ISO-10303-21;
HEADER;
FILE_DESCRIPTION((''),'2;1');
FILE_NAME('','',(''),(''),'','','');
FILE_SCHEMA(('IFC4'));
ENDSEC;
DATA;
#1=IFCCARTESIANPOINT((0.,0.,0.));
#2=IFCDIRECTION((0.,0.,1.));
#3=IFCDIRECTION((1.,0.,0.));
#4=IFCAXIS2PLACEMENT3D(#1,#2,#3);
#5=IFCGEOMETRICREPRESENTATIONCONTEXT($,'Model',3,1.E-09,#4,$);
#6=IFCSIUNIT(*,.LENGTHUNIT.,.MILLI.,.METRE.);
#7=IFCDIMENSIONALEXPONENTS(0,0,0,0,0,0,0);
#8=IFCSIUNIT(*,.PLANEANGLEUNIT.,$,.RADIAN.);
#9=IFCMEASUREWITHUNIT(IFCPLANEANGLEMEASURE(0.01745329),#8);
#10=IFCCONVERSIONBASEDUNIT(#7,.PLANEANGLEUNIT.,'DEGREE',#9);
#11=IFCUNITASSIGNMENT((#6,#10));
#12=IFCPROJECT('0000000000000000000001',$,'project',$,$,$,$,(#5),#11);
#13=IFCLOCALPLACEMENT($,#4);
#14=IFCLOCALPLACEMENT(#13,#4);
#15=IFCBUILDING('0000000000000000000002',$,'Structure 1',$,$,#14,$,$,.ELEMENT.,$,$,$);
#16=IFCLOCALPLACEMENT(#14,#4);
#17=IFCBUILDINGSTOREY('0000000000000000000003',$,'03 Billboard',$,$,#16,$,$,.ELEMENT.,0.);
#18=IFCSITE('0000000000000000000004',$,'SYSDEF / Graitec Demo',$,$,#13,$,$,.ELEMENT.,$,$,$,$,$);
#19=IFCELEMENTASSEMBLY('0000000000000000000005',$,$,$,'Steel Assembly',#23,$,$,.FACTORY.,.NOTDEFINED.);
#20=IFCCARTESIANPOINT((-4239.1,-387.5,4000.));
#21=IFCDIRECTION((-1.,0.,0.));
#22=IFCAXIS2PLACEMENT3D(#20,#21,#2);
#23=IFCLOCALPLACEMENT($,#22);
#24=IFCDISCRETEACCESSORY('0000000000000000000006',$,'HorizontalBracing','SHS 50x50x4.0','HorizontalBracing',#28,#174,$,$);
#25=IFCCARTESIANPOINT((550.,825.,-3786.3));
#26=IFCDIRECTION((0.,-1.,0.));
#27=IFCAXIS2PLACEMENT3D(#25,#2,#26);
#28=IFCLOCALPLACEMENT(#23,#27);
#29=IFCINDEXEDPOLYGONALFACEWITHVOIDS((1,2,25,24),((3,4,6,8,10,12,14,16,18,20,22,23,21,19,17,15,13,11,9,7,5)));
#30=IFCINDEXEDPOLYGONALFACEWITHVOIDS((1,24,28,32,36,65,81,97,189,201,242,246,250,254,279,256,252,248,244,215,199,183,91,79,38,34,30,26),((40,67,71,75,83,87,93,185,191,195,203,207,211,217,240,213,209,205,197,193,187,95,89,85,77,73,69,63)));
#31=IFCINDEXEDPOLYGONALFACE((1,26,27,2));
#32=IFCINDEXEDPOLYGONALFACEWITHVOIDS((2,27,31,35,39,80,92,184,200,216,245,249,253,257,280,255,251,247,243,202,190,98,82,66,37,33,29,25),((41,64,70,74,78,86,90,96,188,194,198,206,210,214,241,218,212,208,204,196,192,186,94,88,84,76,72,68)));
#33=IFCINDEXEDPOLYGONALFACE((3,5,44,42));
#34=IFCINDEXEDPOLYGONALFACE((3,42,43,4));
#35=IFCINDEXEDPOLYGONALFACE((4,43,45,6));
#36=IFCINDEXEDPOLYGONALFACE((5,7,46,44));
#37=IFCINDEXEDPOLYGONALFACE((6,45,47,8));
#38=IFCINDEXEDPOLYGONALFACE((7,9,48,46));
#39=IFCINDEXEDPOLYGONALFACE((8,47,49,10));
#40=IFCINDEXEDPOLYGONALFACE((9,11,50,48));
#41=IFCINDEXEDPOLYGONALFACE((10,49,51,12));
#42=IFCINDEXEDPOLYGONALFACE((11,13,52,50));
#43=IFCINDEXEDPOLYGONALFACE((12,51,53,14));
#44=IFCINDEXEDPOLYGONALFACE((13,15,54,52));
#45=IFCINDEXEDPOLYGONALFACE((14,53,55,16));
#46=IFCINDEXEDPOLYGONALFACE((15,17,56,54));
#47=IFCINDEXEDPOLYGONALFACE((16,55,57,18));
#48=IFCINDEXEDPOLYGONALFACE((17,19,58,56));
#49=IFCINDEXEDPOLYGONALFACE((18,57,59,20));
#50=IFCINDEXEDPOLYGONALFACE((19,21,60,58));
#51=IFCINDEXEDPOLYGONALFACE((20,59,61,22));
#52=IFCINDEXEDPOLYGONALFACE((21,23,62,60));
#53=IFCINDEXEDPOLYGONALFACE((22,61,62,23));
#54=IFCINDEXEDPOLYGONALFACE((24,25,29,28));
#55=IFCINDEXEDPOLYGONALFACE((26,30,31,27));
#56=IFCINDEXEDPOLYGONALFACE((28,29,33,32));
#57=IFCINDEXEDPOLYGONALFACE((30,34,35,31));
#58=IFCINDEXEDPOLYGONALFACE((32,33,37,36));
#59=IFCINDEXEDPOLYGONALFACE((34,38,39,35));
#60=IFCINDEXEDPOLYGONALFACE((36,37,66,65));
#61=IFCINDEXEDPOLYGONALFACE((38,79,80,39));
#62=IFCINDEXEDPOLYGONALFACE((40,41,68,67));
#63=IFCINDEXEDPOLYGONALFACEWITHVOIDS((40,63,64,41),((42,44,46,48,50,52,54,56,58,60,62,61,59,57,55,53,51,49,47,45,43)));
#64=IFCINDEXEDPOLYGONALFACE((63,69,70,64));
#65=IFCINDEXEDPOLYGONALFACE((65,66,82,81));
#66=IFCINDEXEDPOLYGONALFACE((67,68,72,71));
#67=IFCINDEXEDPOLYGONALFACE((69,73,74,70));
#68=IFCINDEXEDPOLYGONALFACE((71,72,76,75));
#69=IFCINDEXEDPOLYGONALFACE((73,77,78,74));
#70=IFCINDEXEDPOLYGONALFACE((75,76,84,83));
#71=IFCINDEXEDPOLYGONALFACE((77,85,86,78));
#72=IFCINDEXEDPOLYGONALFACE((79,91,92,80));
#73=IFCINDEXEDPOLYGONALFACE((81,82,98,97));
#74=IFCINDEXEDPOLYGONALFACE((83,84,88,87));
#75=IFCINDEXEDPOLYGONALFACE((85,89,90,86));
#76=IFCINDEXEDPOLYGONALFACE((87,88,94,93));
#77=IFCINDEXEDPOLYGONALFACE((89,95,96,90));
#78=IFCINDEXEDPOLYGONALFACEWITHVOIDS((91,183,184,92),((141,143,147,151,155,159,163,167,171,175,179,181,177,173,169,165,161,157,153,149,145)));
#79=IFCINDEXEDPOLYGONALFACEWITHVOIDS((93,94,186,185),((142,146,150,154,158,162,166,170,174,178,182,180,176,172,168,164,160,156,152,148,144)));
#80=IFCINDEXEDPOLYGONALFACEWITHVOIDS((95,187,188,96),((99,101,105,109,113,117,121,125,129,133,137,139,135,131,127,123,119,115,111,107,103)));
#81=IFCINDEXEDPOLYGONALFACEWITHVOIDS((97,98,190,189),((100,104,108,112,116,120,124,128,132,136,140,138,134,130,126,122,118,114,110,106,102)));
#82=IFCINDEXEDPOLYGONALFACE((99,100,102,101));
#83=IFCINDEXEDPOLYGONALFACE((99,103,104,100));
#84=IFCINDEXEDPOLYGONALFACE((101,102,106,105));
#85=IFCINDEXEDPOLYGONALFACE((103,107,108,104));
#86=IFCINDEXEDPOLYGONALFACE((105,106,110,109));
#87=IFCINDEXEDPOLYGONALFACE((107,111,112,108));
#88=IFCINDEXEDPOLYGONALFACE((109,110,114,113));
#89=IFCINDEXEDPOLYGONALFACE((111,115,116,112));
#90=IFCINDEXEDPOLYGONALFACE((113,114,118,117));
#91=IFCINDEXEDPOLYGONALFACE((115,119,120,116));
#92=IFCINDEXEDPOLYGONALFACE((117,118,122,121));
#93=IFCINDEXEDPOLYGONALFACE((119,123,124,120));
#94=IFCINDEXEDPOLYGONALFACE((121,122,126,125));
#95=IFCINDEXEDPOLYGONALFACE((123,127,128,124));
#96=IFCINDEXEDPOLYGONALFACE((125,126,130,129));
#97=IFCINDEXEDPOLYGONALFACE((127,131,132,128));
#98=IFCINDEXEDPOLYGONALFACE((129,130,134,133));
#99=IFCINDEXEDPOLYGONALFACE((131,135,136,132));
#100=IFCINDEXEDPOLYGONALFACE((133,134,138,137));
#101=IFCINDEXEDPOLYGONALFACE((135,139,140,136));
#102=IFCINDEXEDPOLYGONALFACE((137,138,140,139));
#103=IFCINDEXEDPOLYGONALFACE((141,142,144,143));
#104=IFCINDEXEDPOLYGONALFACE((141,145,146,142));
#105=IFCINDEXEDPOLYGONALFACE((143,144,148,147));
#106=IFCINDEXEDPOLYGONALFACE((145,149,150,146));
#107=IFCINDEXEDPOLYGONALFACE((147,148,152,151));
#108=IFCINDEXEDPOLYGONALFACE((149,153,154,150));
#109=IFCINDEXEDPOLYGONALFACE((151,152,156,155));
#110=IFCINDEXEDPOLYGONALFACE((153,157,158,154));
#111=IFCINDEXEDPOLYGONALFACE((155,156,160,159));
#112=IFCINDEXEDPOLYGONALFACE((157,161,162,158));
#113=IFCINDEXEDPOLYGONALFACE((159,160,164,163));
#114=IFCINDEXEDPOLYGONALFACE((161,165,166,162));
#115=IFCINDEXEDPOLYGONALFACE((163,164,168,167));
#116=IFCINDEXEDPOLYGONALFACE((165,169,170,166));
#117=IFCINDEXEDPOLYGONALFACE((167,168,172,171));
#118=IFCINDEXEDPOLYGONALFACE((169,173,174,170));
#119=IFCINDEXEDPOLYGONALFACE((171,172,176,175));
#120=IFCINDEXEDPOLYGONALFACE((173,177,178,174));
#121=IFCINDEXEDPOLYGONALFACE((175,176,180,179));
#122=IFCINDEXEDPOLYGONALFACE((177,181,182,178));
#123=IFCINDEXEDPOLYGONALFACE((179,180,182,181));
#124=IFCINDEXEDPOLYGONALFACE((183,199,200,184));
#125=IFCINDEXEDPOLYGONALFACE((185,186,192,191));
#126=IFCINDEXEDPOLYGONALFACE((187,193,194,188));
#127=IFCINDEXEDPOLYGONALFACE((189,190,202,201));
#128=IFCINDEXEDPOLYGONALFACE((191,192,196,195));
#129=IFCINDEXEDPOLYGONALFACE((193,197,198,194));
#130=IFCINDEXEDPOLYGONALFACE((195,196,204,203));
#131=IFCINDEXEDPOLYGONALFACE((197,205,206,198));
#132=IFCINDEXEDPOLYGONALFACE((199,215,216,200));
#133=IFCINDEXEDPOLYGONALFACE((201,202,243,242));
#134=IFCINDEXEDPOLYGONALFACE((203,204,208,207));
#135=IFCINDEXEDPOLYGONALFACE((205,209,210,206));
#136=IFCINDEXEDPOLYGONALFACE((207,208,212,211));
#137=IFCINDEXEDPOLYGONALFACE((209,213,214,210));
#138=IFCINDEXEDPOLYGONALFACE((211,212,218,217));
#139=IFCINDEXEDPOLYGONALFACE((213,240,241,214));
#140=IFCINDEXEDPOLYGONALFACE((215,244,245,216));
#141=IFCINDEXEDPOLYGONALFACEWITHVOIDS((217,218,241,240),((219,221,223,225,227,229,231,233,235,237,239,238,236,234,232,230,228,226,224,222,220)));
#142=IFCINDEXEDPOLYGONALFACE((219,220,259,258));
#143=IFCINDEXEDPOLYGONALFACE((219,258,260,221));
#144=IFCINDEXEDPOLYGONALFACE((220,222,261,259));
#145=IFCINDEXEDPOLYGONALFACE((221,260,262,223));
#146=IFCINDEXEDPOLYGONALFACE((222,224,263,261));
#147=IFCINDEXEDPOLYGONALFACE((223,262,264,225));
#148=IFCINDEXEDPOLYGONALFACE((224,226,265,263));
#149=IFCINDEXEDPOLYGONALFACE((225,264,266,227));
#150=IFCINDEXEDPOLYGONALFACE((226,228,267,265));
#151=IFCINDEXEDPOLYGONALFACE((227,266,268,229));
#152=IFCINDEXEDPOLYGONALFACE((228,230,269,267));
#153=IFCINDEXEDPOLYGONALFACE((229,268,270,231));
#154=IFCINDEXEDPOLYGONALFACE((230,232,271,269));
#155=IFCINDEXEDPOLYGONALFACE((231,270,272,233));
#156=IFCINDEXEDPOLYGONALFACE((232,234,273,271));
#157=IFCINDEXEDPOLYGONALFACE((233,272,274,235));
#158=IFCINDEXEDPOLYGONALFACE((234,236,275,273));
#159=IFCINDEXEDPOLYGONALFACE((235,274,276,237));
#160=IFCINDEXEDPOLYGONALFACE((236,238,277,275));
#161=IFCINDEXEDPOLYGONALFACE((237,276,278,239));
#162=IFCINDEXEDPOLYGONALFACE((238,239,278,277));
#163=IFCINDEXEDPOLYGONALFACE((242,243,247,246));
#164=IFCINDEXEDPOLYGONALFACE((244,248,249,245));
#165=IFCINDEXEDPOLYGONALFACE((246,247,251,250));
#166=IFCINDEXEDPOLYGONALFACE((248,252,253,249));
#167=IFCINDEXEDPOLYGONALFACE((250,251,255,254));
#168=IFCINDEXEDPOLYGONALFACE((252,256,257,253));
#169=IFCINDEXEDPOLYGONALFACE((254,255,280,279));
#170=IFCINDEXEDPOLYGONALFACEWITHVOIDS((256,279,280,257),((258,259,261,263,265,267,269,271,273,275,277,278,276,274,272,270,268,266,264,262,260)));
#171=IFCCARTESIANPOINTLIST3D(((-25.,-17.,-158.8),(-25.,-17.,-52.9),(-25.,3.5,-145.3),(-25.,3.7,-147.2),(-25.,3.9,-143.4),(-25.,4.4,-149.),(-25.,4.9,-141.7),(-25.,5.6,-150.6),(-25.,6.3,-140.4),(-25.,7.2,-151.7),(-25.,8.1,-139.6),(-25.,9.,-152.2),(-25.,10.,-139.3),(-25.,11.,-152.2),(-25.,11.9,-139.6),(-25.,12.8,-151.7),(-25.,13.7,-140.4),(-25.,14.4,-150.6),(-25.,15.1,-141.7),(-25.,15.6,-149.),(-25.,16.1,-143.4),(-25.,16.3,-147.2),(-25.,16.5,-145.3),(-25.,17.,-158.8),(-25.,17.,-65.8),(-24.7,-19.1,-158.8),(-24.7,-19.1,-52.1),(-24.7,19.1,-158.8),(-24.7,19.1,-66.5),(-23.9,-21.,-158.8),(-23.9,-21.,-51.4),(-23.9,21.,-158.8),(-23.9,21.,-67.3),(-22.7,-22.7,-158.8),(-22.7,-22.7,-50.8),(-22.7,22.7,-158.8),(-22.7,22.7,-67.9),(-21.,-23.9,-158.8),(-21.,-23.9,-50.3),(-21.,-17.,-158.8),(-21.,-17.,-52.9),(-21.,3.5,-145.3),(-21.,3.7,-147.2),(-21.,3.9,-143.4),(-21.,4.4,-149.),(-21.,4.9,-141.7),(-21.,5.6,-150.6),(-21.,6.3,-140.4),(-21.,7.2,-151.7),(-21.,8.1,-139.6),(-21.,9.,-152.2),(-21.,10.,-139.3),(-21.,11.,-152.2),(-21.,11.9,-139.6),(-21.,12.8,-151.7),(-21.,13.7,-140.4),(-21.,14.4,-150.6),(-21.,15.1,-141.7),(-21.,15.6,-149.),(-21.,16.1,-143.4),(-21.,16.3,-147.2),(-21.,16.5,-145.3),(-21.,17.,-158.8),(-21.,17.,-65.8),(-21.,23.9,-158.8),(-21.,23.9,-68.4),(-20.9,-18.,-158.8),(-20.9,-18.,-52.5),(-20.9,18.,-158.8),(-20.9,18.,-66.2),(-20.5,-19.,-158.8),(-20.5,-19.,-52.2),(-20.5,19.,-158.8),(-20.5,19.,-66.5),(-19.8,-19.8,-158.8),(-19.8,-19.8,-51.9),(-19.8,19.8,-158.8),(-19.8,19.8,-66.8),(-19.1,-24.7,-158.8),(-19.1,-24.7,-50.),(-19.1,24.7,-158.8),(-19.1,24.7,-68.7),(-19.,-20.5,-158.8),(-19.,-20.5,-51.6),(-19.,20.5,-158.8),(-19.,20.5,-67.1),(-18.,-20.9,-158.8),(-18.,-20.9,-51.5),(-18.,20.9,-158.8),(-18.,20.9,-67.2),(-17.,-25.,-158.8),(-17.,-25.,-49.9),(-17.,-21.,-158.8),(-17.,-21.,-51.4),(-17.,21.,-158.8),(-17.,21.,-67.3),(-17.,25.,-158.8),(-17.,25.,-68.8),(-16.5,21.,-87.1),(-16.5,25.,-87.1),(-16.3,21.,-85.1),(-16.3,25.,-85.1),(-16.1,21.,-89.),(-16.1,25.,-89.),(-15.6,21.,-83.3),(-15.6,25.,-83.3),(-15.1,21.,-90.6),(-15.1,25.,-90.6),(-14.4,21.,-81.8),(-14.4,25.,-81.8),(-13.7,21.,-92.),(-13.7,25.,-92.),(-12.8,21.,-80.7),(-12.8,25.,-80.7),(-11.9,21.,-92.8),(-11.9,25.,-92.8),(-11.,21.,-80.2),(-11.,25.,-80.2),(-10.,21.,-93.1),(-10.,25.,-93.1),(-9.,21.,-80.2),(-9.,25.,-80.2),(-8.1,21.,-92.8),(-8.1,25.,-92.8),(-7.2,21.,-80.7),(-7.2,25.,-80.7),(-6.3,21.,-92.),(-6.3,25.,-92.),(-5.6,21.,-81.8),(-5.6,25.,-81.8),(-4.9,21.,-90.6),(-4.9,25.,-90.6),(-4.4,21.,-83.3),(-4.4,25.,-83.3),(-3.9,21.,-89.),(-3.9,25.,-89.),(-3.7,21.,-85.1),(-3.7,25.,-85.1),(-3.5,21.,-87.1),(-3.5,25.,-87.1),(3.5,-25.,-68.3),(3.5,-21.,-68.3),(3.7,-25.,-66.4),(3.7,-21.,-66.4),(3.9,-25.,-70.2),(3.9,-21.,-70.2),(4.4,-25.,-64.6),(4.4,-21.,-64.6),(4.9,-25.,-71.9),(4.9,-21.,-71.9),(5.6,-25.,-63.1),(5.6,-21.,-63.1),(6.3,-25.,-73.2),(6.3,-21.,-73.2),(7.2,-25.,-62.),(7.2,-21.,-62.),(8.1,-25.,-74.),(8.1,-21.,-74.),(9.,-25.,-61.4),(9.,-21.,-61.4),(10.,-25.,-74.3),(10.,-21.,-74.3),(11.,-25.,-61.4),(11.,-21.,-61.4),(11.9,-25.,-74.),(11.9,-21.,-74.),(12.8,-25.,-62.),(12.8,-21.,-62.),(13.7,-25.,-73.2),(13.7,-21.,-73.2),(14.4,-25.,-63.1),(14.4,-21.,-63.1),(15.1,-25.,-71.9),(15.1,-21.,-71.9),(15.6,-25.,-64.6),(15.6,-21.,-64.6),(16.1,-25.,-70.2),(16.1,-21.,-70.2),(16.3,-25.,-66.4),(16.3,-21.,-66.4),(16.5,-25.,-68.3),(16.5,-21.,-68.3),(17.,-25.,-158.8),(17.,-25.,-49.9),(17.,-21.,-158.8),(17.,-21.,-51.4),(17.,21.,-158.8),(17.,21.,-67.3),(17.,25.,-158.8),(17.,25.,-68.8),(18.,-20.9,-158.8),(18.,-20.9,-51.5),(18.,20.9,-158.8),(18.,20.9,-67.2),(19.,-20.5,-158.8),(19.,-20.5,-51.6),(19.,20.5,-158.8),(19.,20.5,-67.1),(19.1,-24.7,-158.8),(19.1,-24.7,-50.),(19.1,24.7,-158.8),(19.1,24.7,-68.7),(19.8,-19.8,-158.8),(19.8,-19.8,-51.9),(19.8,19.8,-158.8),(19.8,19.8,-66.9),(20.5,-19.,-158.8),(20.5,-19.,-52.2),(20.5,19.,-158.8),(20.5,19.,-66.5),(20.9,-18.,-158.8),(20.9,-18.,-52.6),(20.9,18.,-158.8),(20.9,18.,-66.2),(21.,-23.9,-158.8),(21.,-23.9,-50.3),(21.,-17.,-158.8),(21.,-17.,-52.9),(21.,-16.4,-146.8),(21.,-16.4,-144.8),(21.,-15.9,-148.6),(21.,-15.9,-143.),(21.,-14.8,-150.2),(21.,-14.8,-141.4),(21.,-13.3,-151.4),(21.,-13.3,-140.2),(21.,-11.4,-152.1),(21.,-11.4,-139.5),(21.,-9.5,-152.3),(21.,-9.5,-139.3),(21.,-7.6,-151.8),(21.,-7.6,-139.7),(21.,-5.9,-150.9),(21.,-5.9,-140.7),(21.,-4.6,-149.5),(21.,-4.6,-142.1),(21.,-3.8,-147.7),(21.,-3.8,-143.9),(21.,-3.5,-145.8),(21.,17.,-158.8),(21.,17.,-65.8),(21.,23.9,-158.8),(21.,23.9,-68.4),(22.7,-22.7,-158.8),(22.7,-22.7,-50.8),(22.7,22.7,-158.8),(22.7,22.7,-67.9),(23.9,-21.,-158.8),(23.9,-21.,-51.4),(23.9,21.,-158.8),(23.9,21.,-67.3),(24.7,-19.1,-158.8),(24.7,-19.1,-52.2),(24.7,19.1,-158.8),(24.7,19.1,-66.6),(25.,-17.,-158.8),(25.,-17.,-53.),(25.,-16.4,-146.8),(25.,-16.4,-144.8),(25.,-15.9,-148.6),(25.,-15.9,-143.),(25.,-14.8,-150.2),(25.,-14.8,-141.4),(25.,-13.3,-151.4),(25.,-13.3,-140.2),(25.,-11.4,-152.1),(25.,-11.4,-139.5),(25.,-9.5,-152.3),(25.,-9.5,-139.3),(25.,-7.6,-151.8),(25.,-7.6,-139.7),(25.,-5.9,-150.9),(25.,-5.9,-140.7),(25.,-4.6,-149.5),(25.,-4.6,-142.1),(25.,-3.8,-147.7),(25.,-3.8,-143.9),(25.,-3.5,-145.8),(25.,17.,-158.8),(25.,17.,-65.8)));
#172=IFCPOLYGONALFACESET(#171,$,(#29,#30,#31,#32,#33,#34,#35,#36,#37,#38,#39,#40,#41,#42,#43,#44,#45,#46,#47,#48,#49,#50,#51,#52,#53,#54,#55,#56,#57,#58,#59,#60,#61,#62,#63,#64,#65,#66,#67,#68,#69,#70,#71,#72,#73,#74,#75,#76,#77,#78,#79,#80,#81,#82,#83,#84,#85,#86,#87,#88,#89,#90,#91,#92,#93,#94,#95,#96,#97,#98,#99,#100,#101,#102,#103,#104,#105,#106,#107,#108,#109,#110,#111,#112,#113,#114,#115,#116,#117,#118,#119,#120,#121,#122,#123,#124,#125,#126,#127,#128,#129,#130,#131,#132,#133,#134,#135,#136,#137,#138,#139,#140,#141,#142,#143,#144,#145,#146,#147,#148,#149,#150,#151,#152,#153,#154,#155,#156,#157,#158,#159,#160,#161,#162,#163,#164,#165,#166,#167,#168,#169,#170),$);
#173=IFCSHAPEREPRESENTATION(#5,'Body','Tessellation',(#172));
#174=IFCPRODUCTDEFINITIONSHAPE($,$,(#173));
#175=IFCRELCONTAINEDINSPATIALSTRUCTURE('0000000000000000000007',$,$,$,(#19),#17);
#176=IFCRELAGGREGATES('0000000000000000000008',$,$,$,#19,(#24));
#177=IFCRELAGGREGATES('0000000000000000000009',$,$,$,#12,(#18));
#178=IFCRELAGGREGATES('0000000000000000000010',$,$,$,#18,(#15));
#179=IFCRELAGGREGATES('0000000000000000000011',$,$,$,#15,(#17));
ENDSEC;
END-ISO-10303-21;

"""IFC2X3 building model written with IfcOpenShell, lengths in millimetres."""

from ifc_helpers import new_model, entity, si_unit, converted_unit, frame, frame_2d, origin, origin_with_axes, origin_2d, origin_2d_with_axis, place, context, project, spatial, hollow_rectangle, circle, extrude, clip, halfspace, element, aggregate, save


model = new_model("IFC2X3")

# Units and contexts
model_context = context("Model", 3, precision=1e-09, world=origin_with_axes())
ifc_project = project(units=[si_unit("LENGTHUNIT", "METRE", prefix="MILLI"), converted_unit("PLANEANGLEUNIT", "DEGREE", entity("IfcPlaneAngleMeasure", 0.01745329), si_unit("PLANEANGLEUNIT", "RADIAN"), dimensions=[0, 0, 0, 0, 0, 0, 0])], contexts=[model_context])

# Site, building, storey
site_placement = place(None, origin_with_axes())
site = spatial("IfcSite", under=ifc_project, at=site_placement, Name="SYSDEF / Graitec Demo", CompositionType="ELEMENT")
building_placement = place(site_placement, origin_with_axes())
building = spatial("IfcBuilding", under=site, at=building_placement, Name="Structure 1", CompositionType="ELEMENT")
storey_placement = place(building_placement, origin_with_axes())
storey = spatial("IfcBuildingStorey", under=building, at=storey_placement, Name="03 Billboard", CompositionType="ELEMENT", Elevation=0.0)

# Element assembly, discrete accessory, openings
assembly_1_placement = place(None, frame((-4239.1, -387.5, 4000.0), z_axis=(-1.0, 0.0, 0.0), x_axis=(0.0, 0.0, 1.0)))
assembly_1 = element("IfcElementAssembly", 1, at=assembly_1_placement, inside=storey, ObjectType="Steel Assembly", AssemblyPlace="FACTORY", PredefinedType="NOTDEFINED")
discrete_accessory_1_placement = place(assembly_1_placement, frame((550.0, 825.0, -3786.3), z_axis=(0.0, 0.0, 1.0), x_axis=(0.0, -1.0, 0.0)))
discrete_accessory_1 = element("IfcDiscreteAccessory", 2, at=discrete_accessory_1_placement, Name="HorizontalBracing", Description="SHS 50x50x4.0", ObjectType="HorizontalBracing", context=model_context, shape_type="Clipping", body=[
    clip(clip(extrude(hollow_rectangle(XDim=50.0, YDim=50.0, WallThickness=4.0, InnerFilletRadius=4.0, OuterFilletRadius=8.0, at=origin_2d()), origin(), (0.0, 0.0, -1.0), 269.2), halfspace(frame((437.5, -4550.0, -158.8), z_axis=(0.0, 0.0, 1.0), x_axis=(1.0, 0.0, 0.0)), True)), halfspace(frame((438.5, -3852.5, 1394.8), z_axis=(-0.000511, -0.3532, -0.935548), x_axis=(-1.0, 0.0, 0.000546)), True)),
])
opening_1_placement = place(discrete_accessory_1_placement, frame((-20.5, 10.0, -145.8), z_axis=(-1.0, 0.0, 0.0), x_axis=(0.0, 0.0, 1.0)))
element("IfcOpeningElement", 3, at=opening_1_placement, cuts=discrete_accessory_1, ObjectType="Opening", context=model_context, shape_type="SweptSolid", body=[
    extrude(circle(Radius=6.5, at=origin_2d_with_axis()), origin(), (0.0, 0.0, 1.0), 5.0),
])
opening_2_placement = place(discrete_accessory_1_placement, frame((25.5, -10.0, -152.3), z_axis=(1.0, 0.0, 0.0), x_axis=(0.0, 1.0, 0.0)))
element("IfcOpeningElement", 4, at=opening_2_placement, cuts=discrete_accessory_1, ObjectType="Opening", context=model_context, shape_type="SweptSolid", body=[
    extrude(circle(Radius=6.5, at=frame_2d((0.0, 6.5), x_axis=(1.0, 0.0))), origin(), (0.0, 0.0, -1.0), 5.0),
])
opening_3_placement = place(discrete_accessory_1_placement, frame((-10.0, 20.5, -86.6), z_axis=(0.0, 1.0, 0.0), x_axis=(0.0, 0.0, -1.0)))
element("IfcOpeningElement", 5, at=opening_3_placement, cuts=discrete_accessory_1, ObjectType="Opening", context=model_context, shape_type="SweptSolid", body=[
    extrude(circle(Radius=6.5, at=origin_2d_with_axis()), origin(), (0.0, 0.0, 1.0), 5.0),
])
opening_4_placement = place(discrete_accessory_1_placement, frame((10.0, -25.5, -67.8), z_axis=(0.0, 1.0, 0.0), x_axis=(0.0, 0.0, -1.0)))
element("IfcOpeningElement", 6, at=opening_4_placement, cuts=discrete_accessory_1, ObjectType="Opening", context=model_context, shape_type="SweptSolid", body=[
    extrude(circle(Radius=6.5, at=origin_2d_with_axis()), origin(), (0.0, 0.0, 1.0), 5.0),
])
aggregate(assembly_1, [discrete_accessory_1])

save(model, "model.ifc")
